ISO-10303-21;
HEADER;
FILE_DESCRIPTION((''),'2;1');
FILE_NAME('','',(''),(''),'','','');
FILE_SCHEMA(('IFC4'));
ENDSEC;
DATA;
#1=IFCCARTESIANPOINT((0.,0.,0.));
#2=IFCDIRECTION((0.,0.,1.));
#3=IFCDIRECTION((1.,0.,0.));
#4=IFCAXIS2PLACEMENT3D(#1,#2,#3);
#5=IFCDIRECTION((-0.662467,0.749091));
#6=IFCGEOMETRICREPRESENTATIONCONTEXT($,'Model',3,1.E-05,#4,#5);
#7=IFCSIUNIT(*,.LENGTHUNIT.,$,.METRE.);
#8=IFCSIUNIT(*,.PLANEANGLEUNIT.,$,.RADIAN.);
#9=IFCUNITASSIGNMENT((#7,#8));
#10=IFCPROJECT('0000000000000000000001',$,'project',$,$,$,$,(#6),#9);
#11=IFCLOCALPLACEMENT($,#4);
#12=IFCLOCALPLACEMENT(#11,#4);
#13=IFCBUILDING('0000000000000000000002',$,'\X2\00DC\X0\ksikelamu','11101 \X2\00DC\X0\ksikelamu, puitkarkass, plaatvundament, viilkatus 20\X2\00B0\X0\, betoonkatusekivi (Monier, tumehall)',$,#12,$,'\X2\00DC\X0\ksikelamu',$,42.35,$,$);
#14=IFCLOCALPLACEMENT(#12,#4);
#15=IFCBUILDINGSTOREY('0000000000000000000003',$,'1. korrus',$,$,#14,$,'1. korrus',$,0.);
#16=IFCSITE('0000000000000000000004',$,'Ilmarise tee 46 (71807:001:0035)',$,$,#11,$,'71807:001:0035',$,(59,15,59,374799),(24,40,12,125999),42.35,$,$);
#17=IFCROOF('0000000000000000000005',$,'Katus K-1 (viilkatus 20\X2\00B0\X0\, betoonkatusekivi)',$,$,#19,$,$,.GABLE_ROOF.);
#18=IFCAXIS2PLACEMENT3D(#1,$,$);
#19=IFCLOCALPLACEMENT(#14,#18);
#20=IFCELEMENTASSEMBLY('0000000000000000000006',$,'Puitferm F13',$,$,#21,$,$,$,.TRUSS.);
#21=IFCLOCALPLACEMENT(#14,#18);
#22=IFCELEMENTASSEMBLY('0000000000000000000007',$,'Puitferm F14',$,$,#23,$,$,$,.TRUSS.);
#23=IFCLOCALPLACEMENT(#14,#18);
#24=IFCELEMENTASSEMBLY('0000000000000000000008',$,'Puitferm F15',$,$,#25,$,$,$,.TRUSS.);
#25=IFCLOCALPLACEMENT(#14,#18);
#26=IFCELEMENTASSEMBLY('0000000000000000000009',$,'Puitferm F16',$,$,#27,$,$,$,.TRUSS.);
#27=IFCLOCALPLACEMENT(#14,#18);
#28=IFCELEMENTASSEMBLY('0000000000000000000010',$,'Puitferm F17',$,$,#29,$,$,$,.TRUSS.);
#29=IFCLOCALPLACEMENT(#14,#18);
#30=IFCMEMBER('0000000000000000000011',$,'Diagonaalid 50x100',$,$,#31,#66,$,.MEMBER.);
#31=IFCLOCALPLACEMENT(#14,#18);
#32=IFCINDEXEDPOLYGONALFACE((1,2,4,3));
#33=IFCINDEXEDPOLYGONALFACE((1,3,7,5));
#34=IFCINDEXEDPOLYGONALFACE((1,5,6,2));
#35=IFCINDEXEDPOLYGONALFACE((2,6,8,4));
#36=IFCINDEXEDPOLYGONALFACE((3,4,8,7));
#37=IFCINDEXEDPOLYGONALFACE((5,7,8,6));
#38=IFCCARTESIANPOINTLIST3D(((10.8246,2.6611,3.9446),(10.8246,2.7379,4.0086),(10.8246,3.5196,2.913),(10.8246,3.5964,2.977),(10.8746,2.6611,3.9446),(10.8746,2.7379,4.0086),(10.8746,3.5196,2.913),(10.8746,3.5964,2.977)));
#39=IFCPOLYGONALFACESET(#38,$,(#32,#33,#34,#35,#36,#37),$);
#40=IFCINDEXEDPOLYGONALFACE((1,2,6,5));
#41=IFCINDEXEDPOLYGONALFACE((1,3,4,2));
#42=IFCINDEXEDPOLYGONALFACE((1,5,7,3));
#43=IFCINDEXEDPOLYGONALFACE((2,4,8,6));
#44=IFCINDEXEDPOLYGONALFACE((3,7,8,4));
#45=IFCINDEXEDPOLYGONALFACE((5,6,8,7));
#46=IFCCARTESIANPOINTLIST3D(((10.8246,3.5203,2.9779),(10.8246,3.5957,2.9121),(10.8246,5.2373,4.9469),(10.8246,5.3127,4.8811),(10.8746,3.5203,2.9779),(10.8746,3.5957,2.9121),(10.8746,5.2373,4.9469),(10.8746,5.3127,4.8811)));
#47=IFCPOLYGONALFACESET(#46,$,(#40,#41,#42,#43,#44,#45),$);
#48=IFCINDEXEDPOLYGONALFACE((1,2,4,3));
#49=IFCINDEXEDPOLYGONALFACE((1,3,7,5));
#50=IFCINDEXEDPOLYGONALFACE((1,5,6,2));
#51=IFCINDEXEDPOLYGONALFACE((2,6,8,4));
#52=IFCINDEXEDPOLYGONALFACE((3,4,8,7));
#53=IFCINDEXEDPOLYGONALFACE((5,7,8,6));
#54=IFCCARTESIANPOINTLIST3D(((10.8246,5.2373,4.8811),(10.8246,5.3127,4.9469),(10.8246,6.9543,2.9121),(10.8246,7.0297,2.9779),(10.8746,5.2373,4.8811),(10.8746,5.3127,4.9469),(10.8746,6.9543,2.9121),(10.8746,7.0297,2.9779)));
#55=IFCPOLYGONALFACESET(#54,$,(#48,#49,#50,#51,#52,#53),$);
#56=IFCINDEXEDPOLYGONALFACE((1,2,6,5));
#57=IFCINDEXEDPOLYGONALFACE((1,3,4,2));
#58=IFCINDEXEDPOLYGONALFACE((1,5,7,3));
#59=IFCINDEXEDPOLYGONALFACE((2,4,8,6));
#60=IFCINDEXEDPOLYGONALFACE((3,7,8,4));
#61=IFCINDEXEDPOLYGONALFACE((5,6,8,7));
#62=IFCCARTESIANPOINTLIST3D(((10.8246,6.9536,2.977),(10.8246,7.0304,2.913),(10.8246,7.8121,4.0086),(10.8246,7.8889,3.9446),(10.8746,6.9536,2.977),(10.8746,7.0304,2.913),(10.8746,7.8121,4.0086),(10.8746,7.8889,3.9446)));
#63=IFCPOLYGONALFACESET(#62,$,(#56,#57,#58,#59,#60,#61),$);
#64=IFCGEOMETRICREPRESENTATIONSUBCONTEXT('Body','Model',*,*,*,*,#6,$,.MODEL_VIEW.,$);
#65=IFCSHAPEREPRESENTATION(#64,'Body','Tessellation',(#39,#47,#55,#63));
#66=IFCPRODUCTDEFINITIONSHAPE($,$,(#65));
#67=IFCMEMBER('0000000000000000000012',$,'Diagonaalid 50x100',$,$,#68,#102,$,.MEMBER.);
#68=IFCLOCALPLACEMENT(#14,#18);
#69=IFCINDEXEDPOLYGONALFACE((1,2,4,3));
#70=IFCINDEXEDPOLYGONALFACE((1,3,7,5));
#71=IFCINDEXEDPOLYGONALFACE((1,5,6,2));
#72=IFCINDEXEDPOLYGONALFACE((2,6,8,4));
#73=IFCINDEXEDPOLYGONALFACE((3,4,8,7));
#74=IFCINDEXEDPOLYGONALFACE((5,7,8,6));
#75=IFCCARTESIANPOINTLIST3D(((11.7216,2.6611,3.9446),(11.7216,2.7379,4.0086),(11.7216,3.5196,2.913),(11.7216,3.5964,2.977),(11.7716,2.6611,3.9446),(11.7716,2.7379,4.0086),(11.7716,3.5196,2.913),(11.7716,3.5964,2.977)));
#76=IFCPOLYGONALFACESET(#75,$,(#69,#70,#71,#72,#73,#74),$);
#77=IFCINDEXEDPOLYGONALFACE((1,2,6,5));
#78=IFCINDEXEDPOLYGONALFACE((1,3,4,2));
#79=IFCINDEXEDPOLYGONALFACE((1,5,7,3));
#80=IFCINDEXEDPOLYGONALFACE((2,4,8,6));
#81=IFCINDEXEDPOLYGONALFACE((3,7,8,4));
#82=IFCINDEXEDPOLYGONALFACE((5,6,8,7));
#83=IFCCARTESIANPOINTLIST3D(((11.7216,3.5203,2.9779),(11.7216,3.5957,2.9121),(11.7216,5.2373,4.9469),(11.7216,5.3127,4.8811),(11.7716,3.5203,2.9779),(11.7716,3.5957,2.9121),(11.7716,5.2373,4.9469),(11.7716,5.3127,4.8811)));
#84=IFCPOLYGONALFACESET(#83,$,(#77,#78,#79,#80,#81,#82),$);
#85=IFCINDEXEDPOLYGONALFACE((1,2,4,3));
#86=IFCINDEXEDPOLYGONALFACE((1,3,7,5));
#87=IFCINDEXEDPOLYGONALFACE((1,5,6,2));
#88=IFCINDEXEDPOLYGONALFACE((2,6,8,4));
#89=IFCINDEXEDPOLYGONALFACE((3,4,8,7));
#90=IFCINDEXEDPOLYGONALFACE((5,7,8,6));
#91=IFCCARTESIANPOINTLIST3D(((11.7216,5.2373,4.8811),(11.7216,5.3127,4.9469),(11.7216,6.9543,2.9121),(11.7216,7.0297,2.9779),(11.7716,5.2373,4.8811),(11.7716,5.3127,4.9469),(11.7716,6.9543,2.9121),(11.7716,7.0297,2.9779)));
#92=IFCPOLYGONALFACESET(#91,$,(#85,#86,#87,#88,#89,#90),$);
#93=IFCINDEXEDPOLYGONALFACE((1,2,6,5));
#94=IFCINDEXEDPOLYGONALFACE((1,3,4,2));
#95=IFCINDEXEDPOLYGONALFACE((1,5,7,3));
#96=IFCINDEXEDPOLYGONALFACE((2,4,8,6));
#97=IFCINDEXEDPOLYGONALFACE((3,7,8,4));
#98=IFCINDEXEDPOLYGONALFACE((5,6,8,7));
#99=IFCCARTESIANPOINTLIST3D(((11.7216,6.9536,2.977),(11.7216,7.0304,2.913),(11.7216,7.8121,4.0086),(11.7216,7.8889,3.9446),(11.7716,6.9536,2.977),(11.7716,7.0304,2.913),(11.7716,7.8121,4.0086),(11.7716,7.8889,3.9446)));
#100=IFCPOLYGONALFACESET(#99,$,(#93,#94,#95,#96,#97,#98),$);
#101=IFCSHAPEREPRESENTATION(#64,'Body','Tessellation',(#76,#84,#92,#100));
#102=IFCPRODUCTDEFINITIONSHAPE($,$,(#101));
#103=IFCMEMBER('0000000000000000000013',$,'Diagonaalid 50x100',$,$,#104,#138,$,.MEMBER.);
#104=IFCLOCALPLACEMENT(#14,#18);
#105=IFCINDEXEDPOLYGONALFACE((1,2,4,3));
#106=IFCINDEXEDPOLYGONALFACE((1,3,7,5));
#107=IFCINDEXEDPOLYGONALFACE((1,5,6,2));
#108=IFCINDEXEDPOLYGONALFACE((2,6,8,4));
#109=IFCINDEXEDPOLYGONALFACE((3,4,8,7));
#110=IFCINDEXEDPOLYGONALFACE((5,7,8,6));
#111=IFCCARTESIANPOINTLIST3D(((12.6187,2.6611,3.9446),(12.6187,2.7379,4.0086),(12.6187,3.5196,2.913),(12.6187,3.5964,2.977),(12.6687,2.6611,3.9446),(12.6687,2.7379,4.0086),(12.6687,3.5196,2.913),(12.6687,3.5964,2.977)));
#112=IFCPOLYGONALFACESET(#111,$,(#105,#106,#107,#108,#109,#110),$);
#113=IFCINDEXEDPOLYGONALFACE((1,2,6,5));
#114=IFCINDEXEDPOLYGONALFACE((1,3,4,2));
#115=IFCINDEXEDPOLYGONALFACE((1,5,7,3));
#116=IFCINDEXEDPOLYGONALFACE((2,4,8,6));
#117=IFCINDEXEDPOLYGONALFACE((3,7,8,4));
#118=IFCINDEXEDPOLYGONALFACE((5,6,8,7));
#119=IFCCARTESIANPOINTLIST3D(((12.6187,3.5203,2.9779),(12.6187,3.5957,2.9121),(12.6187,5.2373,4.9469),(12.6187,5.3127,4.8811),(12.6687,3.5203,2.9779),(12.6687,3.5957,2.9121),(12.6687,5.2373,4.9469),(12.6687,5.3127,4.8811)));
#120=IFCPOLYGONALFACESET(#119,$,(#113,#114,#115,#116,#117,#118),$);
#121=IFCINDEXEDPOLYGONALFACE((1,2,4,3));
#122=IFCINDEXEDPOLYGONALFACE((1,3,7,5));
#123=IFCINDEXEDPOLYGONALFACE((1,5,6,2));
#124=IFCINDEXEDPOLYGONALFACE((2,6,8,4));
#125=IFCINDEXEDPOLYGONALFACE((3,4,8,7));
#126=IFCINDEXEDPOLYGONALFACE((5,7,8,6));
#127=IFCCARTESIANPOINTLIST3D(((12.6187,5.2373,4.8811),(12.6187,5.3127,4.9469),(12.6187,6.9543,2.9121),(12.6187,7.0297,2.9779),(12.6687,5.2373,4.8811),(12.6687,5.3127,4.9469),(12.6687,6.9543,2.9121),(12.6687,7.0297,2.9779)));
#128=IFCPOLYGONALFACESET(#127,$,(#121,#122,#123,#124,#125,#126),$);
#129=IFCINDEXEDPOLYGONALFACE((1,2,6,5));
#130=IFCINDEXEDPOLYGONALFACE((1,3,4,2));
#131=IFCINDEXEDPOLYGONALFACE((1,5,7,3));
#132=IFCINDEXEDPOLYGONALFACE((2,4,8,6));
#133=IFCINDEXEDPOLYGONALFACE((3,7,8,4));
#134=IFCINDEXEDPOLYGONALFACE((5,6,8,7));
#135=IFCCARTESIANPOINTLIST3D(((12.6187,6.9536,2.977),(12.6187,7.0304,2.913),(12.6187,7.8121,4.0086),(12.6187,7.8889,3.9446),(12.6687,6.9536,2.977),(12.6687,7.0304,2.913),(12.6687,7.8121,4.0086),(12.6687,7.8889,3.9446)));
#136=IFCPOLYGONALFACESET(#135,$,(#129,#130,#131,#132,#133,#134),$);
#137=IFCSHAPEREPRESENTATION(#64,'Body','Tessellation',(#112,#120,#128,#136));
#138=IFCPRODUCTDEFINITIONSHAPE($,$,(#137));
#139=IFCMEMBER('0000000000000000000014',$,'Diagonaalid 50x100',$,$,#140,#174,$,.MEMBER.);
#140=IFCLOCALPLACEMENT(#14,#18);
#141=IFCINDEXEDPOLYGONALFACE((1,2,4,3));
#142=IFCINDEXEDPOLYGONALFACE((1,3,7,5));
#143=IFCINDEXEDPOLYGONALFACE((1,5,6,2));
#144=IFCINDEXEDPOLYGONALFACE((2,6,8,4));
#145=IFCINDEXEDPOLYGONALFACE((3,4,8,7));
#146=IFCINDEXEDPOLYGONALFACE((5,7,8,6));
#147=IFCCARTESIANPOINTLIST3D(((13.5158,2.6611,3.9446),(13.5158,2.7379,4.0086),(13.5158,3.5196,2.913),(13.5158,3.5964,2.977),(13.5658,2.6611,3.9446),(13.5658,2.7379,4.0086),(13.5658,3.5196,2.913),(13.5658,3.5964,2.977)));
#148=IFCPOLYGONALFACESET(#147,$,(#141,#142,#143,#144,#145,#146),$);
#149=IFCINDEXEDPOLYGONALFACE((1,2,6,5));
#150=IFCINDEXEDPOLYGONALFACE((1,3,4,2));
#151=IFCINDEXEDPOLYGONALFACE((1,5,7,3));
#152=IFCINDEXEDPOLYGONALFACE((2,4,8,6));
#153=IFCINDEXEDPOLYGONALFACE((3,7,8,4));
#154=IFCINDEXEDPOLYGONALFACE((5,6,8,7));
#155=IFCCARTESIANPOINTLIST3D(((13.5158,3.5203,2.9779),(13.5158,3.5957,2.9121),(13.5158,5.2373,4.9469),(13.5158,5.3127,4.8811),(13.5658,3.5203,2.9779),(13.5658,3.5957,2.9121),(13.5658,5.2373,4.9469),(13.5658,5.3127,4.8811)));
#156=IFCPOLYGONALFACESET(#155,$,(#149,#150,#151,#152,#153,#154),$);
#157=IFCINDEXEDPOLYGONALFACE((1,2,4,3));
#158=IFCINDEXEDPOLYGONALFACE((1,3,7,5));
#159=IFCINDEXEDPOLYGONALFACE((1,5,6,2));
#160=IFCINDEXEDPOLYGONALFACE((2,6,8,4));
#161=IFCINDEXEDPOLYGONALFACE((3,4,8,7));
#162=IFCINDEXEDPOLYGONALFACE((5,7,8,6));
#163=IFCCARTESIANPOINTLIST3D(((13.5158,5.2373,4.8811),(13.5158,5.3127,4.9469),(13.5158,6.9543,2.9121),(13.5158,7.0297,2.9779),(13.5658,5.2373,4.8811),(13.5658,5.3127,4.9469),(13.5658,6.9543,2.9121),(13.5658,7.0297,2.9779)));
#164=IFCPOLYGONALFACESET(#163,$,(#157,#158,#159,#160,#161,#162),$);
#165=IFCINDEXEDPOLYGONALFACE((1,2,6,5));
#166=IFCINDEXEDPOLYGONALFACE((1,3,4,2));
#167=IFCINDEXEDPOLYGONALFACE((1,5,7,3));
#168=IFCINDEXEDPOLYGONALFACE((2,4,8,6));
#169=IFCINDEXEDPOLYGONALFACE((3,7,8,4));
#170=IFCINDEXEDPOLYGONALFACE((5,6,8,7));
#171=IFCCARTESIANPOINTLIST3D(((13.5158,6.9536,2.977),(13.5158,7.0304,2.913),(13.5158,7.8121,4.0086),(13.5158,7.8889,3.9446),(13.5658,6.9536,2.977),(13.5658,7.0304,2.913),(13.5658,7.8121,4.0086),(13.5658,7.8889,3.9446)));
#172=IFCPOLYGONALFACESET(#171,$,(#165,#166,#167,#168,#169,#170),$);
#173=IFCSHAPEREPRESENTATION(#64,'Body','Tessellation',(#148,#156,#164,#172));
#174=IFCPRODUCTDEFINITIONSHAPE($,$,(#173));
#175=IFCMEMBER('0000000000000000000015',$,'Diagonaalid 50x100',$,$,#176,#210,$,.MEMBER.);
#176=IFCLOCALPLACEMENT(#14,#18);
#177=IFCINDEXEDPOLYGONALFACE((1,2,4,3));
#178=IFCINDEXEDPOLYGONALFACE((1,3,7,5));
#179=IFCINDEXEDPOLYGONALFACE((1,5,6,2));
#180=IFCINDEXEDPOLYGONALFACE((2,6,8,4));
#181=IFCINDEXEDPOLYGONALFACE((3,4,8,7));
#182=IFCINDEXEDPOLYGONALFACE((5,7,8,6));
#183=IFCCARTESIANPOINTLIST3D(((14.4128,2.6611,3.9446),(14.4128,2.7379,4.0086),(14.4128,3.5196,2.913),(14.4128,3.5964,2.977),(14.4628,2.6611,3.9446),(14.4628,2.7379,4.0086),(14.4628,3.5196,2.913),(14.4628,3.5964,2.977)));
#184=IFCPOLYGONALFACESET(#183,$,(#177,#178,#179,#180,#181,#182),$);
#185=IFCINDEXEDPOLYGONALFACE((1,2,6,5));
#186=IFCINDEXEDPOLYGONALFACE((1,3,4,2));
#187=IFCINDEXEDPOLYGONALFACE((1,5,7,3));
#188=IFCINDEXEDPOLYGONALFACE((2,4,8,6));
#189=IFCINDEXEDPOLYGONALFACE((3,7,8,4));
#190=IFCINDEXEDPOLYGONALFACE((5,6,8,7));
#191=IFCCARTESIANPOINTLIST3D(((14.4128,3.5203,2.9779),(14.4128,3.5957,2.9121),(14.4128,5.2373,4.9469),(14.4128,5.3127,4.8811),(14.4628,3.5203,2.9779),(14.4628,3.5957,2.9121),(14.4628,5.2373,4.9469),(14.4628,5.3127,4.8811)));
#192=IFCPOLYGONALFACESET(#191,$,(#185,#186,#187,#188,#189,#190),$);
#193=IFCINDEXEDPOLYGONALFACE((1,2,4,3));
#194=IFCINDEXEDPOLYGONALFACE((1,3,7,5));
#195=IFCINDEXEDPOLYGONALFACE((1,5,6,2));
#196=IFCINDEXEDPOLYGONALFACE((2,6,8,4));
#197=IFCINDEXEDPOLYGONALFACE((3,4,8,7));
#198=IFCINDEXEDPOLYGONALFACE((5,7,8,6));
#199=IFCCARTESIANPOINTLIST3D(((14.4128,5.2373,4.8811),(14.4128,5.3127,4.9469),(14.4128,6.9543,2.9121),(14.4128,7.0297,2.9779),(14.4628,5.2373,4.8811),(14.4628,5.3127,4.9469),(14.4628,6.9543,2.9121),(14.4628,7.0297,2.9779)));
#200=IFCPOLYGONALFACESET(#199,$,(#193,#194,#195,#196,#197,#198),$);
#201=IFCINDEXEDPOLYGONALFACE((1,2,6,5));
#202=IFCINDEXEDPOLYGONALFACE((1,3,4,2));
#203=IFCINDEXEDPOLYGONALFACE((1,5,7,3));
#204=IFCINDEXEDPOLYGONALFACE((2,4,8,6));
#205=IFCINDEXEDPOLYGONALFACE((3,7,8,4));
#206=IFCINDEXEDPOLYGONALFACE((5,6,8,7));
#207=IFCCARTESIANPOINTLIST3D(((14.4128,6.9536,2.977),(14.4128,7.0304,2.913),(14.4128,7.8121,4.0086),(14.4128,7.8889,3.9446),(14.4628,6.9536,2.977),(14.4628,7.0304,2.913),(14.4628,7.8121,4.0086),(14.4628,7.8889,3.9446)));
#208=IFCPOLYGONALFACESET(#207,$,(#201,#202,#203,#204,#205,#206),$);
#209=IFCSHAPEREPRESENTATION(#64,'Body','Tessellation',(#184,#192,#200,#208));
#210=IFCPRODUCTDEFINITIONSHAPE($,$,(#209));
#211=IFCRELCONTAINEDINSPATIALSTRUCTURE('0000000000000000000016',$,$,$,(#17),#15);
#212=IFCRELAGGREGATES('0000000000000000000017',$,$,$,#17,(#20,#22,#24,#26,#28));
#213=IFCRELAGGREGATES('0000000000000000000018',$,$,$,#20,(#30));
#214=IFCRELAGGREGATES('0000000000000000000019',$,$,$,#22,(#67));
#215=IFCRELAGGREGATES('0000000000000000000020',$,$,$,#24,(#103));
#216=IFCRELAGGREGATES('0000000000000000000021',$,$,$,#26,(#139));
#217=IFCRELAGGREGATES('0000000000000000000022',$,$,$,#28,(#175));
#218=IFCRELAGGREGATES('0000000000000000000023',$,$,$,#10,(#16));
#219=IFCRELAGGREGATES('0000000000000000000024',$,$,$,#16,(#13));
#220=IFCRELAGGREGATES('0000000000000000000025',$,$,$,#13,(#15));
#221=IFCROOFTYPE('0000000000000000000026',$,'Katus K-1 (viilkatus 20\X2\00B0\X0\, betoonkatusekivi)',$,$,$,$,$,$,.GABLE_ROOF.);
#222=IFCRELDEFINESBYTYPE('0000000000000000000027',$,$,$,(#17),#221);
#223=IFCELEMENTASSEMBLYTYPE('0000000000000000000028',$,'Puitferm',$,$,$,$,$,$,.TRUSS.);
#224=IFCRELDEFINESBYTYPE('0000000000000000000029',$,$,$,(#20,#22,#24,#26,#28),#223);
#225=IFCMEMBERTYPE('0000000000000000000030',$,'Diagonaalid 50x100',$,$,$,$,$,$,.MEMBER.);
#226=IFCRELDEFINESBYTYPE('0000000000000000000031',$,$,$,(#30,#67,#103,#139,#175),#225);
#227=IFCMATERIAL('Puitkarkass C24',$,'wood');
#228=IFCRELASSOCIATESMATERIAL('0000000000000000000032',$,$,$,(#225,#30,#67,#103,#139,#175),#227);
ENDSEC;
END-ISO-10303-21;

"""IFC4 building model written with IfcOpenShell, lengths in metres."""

from ifc_helpers import new_model, si_unit, direction, frame, origin_with_axes, place, context, subcontext, project, spatial, indexed_curve, outline, extrude, material, type_object, element, aggregate, save


model = new_model("IFC4")

# Units and contexts
model_context = context("Model", 3, precision=1e-05, world=origin_with_axes(), true_north=direction((-0.662467, 0.749091)))
body_context = subcontext(model_context, "Body", "Model", "MODEL_VIEW")
ifc_project = project(units=[si_unit("LENGTHUNIT", "METRE"), si_unit("PLANEANGLEUNIT", "RADIAN")], contexts=[model_context])

# Site, building, storey
site_placement = place(None, origin_with_axes())
site = spatial("IfcSite", under=ifc_project, at=site_placement, Name="Ilmarise tee 46 (71807:001:0035)", LongName="71807:001:0035", RefLatitude=(59, 15, 59, 374799), RefLongitude=(24, 40, 12, 125999), RefElevation=42.35)
building_placement = place(site_placement, origin_with_axes())
building = spatial("IfcBuilding", under=site, at=building_placement, Name="Üksikelamu", Description="11101 Üksikelamu, puitkarkass, plaatvundament, viilkatus 20°, betoonkatusekivi (Monier, tumehall)", LongName="Üksikelamu", ElevationOfRefHeight=42.35)
storey_placement = place(building_placement, origin_with_axes())
storey = spatial("IfcBuildingStorey", under=building, at=storey_placement, Name="1. korrus", LongName="1. korrus", Elevation=0.0)

# Roof, element assemblies, members
roof_type = type_object("IfcRoofType", Name="Katus K-1 (viilkatus 20°, betoonkatusekivi)", PredefinedType="GABLE_ROOF")
roof_placement = place(storey_placement, origin_with_axes())
roof = element("IfcRoof", 1, at=roof_placement, inside=storey, type_object=roof_type, Name="Katus K-1 (viilkatus 20°, betoonkatusekivi)", PredefinedType="GABLE_ROOF")
element_assembly_type = type_object("IfcElementAssemblyType", Name="Puitferm", PredefinedType="TRUSS")
assembly_1_placement = place(roof_placement, origin_with_axes())
assembly_1 = element("IfcElementAssembly", 2, at=assembly_1_placement, type_object=element_assembly_type, Name="Puitferm F13", PredefinedType="TRUSS")
ifc_material = material(Name="Puitkarkass C24", Category="wood")
assembly_2_placement = place(roof_placement, origin_with_axes())
assembly_2 = element("IfcElementAssembly", 3, at=assembly_2_placement, type_object=element_assembly_type, Name="Puitferm F14", PredefinedType="TRUSS")
assembly_3_placement = place(roof_placement, origin_with_axes())
assembly_3 = element("IfcElementAssembly", 4, at=assembly_3_placement, type_object=element_assembly_type, Name="Puitferm F15", PredefinedType="TRUSS")
assembly_4_placement = place(roof_placement, origin_with_axes())
assembly_4 = element("IfcElementAssembly", 5, at=assembly_4_placement, type_object=element_assembly_type, Name="Puitferm F16", PredefinedType="TRUSS")
assembly_5_placement = place(roof_placement, origin_with_axes())
assembly_5 = element("IfcElementAssembly", 6, at=assembly_5_placement, type_object=element_assembly_type, Name="Puitferm F17", PredefinedType="TRUSS")
aggregate(roof, [assembly_1, assembly_2, assembly_3, assembly_4, assembly_5])
member_type_1 = type_object("IfcMemberType", Name="Diagonaalid 50x100", PredefinedType="MEMBER", material=ifc_material)
member_1_placement = place(assembly_1_placement, origin_with_axes())
member_1 = element("IfcMember", 7, at=member_1_placement, type_object=member_type_1, material=ifc_material, Name="Diagonaalid 50x100", PredefinedType="MEMBER", context=body_context, shape_type="SweptSolid", body=[
    extrude(outline(indexed_curve([(3.5196, 2.913), (2.6611, 3.9446), (2.7379, 4.0086), (3.5964, 2.977), (3.5196, 2.913)], self_intersect=False)), frame((10.8246, 0.0, 0.0), z_axis=(1.0, 0.0, 0.0), x_axis=(0.0, 1.0, 0.0)), (0.0, 0.0, 1.0), 0.05),
    extrude(outline(indexed_curve([(3.5203, 2.9779), (5.2373, 4.9469), (5.3127, 4.8811), (3.5957, 2.9121), (3.5203, 2.9779)], self_intersect=False)), frame((10.8246, 0.0, 0.0), z_axis=(1.0, 0.0, 0.0), x_axis=(0.0, 1.0, 0.0)), (0.0, 0.0, 1.0), 0.05),
    extrude(outline(indexed_curve([(6.9543, 2.9121), (5.2373, 4.8811), (5.3127, 4.9469), (7.0297, 2.9779), (6.9543, 2.9121)], self_intersect=False)), frame((10.8246, 0.0, 0.0), z_axis=(1.0, 0.0, 0.0), x_axis=(0.0, 1.0, 0.0)), (0.0, 0.0, 1.0), 0.05),
    extrude(outline(indexed_curve([(6.9536, 2.977), (7.8121, 4.0086), (7.8889, 3.9446), (7.0304, 2.913), (6.9536, 2.977)], self_intersect=False)), frame((10.8246, 0.0, 0.0), z_axis=(1.0, 0.0, 0.0), x_axis=(0.0, 1.0, 0.0)), (0.0, 0.0, 1.0), 0.05),
])
aggregate(assembly_1, [member_1])
member_2_placement = place(assembly_2_placement, origin_with_axes())
member_2 = element("IfcMember", 8, at=member_2_placement, type_object=member_type_1, material=ifc_material, Name="Diagonaalid 50x100", PredefinedType="MEMBER", context=body_context, shape_type="SweptSolid", body=[
    extrude(outline(indexed_curve([(3.5196, 2.913), (2.6611, 3.9446), (2.7379, 4.0086), (3.5964, 2.977), (3.5196, 2.913)], self_intersect=False)), frame((11.7216, 0.0, 0.0), z_axis=(1.0, 0.0, 0.0), x_axis=(0.0, 1.0, 0.0)), (0.0, 0.0, 1.0), 0.05),
    extrude(outline(indexed_curve([(3.5203, 2.9779), (5.2373, 4.9469), (5.3127, 4.8811), (3.5957, 2.9121), (3.5203, 2.9779)], self_intersect=False)), frame((11.7216, 0.0, 0.0), z_axis=(1.0, 0.0, 0.0), x_axis=(0.0, 1.0, 0.0)), (0.0, 0.0, 1.0), 0.05),
    extrude(outline(indexed_curve([(6.9543, 2.9121), (5.2373, 4.8811), (5.3127, 4.9469), (7.0297, 2.9779), (6.9543, 2.9121)], self_intersect=False)), frame((11.7216, 0.0, 0.0), z_axis=(1.0, 0.0, 0.0), x_axis=(0.0, 1.0, 0.0)), (0.0, 0.0, 1.0), 0.05),
    extrude(outline(indexed_curve([(6.9536, 2.977), (7.8121, 4.0086), (7.8889, 3.9446), (7.0304, 2.913), (6.9536, 2.977)], self_intersect=False)), frame((11.7216, 0.0, 0.0), z_axis=(1.0, 0.0, 0.0), x_axis=(0.0, 1.0, 0.0)), (0.0, 0.0, 1.0), 0.05),
])
aggregate(assembly_2, [member_2])
member_3_placement = place(assembly_3_placement, origin_with_axes())
member_3 = element("IfcMember", 9, at=member_3_placement, type_object=member_type_1, material=ifc_material, Name="Diagonaalid 50x100", PredefinedType="MEMBER", context=body_context, shape_type="SweptSolid", body=[
    extrude(outline(indexed_curve([(3.5196, 2.913), (2.6611, 3.9446), (2.7379, 4.0086), (3.5964, 2.977), (3.5196, 2.913)], self_intersect=False)), frame((12.6187, 0.0, 0.0), z_axis=(1.0, 0.0, 0.0), x_axis=(0.0, 1.0, 0.0)), (0.0, 0.0, 1.0), 0.05),
    extrude(outline(indexed_curve([(3.5203, 2.9779), (5.2373, 4.9469), (5.3127, 4.8811), (3.5957, 2.9121), (3.5203, 2.9779)], self_intersect=False)), frame((12.6187, 0.0, 0.0), z_axis=(1.0, 0.0, 0.0), x_axis=(0.0, 1.0, 0.0)), (0.0, 0.0, 1.0), 0.05),
    extrude(outline(indexed_curve([(6.9543, 2.9121), (5.2373, 4.8811), (5.3127, 4.9469), (7.0297, 2.9779), (6.9543, 2.9121)], self_intersect=False)), frame((12.6187, 0.0, 0.0), z_axis=(1.0, 0.0, 0.0), x_axis=(0.0, 1.0, 0.0)), (0.0, 0.0, 1.0), 0.05),
    extrude(outline(indexed_curve([(6.9536, 2.977), (7.8121, 4.0086), (7.8889, 3.9446), (7.0304, 2.913), (6.9536, 2.977)], self_intersect=False)), frame((12.6187, 0.0, 0.0), z_axis=(1.0, 0.0, 0.0), x_axis=(0.0, 1.0, 0.0)), (0.0, 0.0, 1.0), 0.05),
])
aggregate(assembly_3, [member_3])
member_4_placement = place(assembly_4_placement, origin_with_axes())
member_4 = element("IfcMember", 10, at=member_4_placement, type_object=member_type_1, material=ifc_material, Name="Diagonaalid 50x100", PredefinedType="MEMBER", context=body_context, shape_type="SweptSolid", body=[
    extrude(outline(indexed_curve([(3.5196, 2.913), (2.6611, 3.9446), (2.7379, 4.0086), (3.5964, 2.977), (3.5196, 2.913)], self_intersect=False)), frame((13.5158, 0.0, 0.0), z_axis=(1.0, 0.0, 0.0), x_axis=(0.0, 1.0, 0.0)), (0.0, 0.0, 1.0), 0.05),
    extrude(outline(indexed_curve([(3.5203, 2.9779), (5.2373, 4.9469), (5.3127, 4.8811), (3.5957, 2.9121), (3.5203, 2.9779)], self_intersect=False)), frame((13.5158, 0.0, 0.0), z_axis=(1.0, 0.0, 0.0), x_axis=(0.0, 1.0, 0.0)), (0.0, 0.0, 1.0), 0.05),
    extrude(outline(indexed_curve([(6.9543, 2.9121), (5.2373, 4.8811), (5.3127, 4.9469), (7.0297, 2.9779), (6.9543, 2.9121)], self_intersect=False)), frame((13.5158, 0.0, 0.0), z_axis=(1.0, 0.0, 0.0), x_axis=(0.0, 1.0, 0.0)), (0.0, 0.0, 1.0), 0.05),
    extrude(outline(indexed_curve([(6.9536, 2.977), (7.8121, 4.0086), (7.8889, 3.9446), (7.0304, 2.913), (6.9536, 2.977)], self_intersect=False)), frame((13.5158, 0.0, 0.0), z_axis=(1.0, 0.0, 0.0), x_axis=(0.0, 1.0, 0.0)), (0.0, 0.0, 1.0), 0.05),
])
aggregate(assembly_4, [member_4])
member_5_placement = place(assembly_5_placement, origin_with_axes())
member_5 = element("IfcMember", 11, at=member_5_placement, type_object=member_type_1, material=ifc_material, Name="Diagonaalid 50x100", PredefinedType="MEMBER", context=body_context, shape_type="SweptSolid", body=[
    extrude(outline(indexed_curve([(3.5196, 2.913), (2.6611, 3.9446), (2.7379, 4.0086), (3.5964, 2.977), (3.5196, 2.913)], self_intersect=False)), frame((14.4128, 0.0, 0.0), z_axis=(1.0, 0.0, 0.0), x_axis=(0.0, 1.0, 0.0)), (0.0, 0.0, 1.0), 0.05),
    extrude(outline(indexed_curve([(3.5203, 2.9779), (5.2373, 4.9469), (5.3127, 4.8811), (3.5957, 2.9121), (3.5203, 2.9779)], self_intersect=False)), frame((14.4128, 0.0, 0.0), z_axis=(1.0, 0.0, 0.0), x_axis=(0.0, 1.0, 0.0)), (0.0, 0.0, 1.0), 0.05),
    extrude(outline(indexed_curve([(6.9543, 2.9121), (5.2373, 4.8811), (5.3127, 4.9469), (7.0297, 2.9779), (6.9543, 2.9121)], self_intersect=False)), frame((14.4128, 0.0, 0.0), z_axis=(1.0, 0.0, 0.0), x_axis=(0.0, 1.0, 0.0)), (0.0, 0.0, 1.0), 0.05),
    extrude(outline(indexed_curve([(6.9536, 2.977), (7.8121, 4.0086), (7.8889, 3.9446), (7.0304, 2.913), (6.9536, 2.977)], self_intersect=False)), frame((14.4128, 0.0, 0.0), z_axis=(1.0, 0.0, 0.0), x_axis=(0.0, 1.0, 0.0)), (0.0, 0.0, 1.0), 0.05),
])
aggregate(assembly_5, [member_5])

save(model, "model.ifc")
